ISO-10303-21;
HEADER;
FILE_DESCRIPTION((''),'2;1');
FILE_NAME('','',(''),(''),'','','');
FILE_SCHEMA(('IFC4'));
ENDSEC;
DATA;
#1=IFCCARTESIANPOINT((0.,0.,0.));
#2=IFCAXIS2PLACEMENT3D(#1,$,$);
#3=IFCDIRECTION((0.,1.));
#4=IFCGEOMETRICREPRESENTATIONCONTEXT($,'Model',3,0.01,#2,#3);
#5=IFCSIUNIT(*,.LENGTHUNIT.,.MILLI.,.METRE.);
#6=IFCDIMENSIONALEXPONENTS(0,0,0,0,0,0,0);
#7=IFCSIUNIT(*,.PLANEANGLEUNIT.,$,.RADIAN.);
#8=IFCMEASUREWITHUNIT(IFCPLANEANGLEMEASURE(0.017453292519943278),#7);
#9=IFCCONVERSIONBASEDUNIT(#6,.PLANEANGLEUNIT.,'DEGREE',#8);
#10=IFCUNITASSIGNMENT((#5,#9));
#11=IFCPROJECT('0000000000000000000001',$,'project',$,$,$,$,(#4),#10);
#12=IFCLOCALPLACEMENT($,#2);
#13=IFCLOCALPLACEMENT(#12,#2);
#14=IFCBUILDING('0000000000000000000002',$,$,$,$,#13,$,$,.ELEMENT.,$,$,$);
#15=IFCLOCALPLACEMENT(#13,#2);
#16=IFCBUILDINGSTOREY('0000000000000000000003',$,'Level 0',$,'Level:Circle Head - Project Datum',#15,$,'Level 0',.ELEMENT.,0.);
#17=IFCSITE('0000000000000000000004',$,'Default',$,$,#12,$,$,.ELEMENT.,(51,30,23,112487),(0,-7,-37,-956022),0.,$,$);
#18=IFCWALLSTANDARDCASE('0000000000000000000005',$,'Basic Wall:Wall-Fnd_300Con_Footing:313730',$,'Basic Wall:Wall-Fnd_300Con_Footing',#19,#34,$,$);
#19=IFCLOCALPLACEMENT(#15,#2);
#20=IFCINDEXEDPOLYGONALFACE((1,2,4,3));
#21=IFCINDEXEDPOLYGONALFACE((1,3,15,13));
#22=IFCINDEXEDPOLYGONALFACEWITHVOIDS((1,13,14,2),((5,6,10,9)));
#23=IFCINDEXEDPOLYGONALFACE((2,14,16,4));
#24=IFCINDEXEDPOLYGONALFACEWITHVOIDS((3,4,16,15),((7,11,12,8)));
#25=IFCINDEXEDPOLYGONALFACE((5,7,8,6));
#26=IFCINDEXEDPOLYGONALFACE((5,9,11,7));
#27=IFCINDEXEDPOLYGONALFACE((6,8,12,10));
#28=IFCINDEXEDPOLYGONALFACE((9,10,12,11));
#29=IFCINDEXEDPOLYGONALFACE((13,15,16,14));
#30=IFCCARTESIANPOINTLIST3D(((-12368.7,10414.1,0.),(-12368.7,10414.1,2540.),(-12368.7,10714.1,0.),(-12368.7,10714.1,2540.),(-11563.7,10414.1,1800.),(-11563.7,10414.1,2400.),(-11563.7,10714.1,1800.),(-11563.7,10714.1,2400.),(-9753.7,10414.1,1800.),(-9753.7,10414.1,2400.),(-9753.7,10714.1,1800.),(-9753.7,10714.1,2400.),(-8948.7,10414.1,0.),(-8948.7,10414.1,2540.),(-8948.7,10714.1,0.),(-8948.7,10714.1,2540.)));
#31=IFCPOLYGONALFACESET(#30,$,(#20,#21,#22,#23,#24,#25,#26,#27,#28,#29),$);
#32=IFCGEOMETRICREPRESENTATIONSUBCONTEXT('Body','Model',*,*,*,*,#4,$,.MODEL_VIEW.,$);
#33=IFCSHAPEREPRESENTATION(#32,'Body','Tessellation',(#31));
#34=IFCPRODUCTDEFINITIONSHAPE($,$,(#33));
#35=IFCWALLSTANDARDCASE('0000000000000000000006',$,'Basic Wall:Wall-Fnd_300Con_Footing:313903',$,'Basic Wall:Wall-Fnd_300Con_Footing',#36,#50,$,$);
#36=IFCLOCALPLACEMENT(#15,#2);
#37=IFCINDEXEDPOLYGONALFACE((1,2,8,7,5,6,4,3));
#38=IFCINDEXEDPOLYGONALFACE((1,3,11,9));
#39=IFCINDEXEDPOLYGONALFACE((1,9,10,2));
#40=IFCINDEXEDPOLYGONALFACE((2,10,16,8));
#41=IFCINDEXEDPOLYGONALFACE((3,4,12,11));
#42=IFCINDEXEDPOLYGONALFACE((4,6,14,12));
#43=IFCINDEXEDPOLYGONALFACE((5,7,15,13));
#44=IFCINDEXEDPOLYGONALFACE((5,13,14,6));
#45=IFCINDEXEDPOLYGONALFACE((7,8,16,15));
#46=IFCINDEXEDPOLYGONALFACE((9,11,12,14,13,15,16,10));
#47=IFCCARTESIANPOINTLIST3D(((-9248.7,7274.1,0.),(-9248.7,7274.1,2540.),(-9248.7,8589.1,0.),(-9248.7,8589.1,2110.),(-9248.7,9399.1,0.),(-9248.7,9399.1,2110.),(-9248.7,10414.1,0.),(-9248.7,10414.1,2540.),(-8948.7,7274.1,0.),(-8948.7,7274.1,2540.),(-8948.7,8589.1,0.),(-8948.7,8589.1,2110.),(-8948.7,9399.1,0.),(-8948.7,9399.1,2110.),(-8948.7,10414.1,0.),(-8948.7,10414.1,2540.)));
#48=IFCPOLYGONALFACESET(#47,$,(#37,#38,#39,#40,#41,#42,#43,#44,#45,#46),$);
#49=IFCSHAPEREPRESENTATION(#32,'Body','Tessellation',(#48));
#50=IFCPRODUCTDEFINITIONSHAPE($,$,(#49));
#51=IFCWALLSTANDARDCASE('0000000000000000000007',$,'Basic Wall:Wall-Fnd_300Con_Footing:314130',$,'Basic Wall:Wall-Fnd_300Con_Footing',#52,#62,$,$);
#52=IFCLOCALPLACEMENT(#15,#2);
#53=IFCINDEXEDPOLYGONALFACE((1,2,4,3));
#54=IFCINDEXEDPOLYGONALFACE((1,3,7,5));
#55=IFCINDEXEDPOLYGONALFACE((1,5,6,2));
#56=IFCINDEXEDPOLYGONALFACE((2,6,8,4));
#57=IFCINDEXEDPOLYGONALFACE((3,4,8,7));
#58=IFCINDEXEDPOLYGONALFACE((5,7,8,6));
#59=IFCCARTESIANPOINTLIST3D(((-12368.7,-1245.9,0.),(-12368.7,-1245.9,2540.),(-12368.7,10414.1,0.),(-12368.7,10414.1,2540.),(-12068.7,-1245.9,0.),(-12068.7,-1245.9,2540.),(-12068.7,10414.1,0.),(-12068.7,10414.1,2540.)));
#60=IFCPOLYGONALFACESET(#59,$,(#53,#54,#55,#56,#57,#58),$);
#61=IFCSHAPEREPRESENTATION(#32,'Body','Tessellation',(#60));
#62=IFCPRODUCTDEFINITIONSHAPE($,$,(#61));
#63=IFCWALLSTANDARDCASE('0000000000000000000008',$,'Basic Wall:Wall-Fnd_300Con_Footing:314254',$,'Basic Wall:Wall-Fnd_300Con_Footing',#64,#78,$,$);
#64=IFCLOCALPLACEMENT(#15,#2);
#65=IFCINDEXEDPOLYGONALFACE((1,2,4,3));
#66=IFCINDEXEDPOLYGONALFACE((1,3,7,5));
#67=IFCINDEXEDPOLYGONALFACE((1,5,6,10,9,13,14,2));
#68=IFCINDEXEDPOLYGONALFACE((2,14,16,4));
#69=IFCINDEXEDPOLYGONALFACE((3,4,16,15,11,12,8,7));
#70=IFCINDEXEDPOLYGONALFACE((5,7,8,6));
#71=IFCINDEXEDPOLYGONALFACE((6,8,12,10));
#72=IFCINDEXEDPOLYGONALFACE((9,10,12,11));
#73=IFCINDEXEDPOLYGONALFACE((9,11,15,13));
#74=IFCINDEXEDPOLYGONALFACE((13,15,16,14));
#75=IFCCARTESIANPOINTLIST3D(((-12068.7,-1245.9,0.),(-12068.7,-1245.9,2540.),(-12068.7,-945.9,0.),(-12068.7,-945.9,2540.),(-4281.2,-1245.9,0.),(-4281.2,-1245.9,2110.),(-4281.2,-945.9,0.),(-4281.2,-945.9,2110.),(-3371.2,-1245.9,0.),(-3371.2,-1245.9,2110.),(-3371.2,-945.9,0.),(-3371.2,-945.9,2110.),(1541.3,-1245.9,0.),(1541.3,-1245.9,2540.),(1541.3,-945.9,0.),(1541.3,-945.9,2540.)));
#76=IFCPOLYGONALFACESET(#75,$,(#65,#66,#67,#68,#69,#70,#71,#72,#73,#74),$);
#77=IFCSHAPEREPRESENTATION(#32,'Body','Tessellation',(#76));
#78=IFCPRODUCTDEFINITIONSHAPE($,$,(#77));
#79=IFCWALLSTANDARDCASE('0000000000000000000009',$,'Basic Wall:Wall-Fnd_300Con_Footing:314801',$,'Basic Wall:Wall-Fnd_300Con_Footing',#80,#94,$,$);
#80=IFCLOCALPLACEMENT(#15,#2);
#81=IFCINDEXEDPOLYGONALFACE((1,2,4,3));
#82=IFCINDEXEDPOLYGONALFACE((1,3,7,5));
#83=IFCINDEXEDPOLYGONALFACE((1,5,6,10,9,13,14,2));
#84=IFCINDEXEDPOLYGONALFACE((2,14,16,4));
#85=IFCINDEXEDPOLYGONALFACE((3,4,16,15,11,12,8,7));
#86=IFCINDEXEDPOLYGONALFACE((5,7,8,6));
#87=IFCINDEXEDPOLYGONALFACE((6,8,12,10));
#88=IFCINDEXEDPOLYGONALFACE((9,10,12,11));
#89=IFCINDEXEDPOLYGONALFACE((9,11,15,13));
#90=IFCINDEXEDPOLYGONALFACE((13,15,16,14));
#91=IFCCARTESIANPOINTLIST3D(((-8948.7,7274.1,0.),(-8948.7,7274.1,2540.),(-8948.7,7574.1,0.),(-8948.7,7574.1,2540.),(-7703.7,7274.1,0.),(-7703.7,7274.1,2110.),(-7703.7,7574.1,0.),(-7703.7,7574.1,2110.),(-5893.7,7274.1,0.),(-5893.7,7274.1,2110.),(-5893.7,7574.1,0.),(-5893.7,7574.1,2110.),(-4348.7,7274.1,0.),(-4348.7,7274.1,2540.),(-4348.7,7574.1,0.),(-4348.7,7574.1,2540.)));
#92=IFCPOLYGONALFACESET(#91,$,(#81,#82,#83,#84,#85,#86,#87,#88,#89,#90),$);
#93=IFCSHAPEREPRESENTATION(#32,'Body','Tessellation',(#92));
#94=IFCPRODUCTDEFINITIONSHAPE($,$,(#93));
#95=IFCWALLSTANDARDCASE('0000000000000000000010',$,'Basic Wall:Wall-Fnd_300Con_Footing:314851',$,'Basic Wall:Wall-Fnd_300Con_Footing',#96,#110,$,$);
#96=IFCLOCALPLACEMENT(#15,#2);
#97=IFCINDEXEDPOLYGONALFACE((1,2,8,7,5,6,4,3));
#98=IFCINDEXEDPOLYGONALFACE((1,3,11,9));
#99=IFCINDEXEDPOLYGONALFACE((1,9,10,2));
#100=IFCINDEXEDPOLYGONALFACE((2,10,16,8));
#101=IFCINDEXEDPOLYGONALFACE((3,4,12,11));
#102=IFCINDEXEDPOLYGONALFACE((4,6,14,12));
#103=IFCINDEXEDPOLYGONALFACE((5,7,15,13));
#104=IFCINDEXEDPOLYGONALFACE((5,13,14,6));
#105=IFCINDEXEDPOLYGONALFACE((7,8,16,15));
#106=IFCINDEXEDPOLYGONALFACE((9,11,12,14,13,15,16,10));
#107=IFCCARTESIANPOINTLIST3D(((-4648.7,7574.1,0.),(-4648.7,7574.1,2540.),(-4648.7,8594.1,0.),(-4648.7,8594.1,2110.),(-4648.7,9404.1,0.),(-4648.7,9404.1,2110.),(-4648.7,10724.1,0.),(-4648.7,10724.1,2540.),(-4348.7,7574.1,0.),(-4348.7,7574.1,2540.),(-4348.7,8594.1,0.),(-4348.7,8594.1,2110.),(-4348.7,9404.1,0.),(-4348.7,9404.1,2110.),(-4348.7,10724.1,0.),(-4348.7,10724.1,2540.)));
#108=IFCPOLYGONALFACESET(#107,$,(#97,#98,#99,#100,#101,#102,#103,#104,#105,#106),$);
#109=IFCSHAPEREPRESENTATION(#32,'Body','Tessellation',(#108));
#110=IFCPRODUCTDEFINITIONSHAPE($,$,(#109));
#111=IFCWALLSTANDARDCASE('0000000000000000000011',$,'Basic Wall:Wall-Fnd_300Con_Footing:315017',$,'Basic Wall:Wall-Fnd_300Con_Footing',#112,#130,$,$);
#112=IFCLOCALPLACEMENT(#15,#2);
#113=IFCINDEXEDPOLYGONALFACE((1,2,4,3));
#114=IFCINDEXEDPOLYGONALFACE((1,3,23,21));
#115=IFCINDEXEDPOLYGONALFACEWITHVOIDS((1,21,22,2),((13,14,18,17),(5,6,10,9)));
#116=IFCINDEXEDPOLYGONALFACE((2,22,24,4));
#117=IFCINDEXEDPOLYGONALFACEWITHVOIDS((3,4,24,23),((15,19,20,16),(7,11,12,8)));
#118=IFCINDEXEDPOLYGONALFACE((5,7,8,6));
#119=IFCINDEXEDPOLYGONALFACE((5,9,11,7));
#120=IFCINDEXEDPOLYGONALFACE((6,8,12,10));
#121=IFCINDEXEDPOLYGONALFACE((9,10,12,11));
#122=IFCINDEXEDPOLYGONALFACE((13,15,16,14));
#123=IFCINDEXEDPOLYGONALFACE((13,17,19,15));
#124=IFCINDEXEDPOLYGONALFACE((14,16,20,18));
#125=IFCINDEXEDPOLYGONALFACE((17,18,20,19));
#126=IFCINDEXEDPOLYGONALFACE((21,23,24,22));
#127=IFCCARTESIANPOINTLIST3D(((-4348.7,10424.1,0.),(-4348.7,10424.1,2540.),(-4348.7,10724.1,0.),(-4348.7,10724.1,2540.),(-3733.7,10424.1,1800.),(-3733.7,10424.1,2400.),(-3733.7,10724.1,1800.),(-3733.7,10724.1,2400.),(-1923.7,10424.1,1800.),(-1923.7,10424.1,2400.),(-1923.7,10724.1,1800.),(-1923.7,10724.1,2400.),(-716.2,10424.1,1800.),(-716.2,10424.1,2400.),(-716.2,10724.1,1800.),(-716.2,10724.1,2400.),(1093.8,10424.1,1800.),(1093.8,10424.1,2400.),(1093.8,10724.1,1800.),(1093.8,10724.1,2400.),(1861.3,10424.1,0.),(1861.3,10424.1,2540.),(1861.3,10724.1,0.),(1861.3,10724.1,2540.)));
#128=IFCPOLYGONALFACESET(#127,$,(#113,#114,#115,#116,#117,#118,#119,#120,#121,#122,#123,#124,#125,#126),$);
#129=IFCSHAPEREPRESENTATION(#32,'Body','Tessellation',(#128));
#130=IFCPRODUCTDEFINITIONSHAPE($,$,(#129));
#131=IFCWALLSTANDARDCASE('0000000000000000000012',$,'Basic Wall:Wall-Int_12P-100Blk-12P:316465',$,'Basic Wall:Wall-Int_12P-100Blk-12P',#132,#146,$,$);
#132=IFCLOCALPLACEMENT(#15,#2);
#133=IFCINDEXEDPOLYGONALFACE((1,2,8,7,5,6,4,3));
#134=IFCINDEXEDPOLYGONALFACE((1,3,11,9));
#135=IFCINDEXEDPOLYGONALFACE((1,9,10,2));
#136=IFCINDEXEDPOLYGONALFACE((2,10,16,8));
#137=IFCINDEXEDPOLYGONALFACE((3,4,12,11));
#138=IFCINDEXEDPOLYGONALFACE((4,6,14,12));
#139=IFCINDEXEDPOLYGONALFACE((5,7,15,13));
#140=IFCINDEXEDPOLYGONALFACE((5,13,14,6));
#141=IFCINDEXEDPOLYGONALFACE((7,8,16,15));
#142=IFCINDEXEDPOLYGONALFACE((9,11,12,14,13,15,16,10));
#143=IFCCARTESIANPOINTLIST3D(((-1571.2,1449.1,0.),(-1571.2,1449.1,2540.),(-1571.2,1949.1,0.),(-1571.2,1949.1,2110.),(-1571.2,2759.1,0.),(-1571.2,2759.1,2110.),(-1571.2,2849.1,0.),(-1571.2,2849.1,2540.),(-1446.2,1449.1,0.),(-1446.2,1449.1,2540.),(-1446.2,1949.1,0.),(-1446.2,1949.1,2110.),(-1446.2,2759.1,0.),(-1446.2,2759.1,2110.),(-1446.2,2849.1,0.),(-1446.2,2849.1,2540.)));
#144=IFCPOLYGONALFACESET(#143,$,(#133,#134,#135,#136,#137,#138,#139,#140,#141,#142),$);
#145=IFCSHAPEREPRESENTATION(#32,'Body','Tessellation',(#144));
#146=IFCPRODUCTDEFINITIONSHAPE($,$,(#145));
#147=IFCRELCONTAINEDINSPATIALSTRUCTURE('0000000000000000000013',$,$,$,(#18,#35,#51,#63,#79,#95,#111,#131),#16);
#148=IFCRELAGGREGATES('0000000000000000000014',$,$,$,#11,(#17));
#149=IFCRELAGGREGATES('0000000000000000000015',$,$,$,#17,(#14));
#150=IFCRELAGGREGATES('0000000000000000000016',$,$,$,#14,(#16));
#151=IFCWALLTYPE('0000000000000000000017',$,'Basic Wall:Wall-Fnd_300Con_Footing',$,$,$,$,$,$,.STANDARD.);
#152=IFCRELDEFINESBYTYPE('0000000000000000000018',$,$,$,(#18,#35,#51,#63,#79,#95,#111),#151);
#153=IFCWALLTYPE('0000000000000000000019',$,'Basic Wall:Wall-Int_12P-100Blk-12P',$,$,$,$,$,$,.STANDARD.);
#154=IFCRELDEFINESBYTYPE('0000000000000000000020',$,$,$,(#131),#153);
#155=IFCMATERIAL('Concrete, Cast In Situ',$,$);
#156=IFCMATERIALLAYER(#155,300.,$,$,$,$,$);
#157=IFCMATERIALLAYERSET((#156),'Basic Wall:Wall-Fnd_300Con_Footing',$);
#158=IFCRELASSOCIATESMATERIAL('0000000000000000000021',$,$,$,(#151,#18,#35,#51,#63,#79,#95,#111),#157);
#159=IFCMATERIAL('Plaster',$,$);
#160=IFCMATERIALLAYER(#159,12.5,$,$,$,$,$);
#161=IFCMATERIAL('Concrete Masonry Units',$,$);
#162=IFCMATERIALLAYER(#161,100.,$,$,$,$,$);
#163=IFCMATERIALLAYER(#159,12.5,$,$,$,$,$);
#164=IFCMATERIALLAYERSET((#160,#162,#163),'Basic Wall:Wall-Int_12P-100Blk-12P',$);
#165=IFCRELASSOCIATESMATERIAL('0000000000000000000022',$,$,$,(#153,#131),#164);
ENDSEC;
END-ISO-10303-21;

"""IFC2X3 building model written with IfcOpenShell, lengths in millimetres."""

from ifc_helpers import new_model, entity, si_unit, converted_unit, direction, frame, frame_2d, origin, place, context, subcontext, project, spatial, rectangle, extrude, material, layer, layer_set, layer_usage, type_object, element, save


model = new_model("IFC2X3")

# Units and contexts
model_context = context("Model", 3, precision=0.01, world=origin(), true_north=direction((0.0, 1.0)))
body_context = subcontext(model_context, "Body", "Model", "MODEL_VIEW")
ifc_project = project(units=[si_unit("LENGTHUNIT", "METRE", prefix="MILLI"), converted_unit("PLANEANGLEUNIT", "DEGREE", entity("IfcPlaneAngleMeasure", 0.017453292519943278), si_unit("PLANEANGLEUNIT", "RADIAN"), dimensions=[0, 0, 0, 0, 0, 0, 0])], contexts=[model_context])

# Site, building, storey
site_placement = place(None, origin())
site = spatial("IfcSite", under=ifc_project, at=site_placement, Name="Default", CompositionType="ELEMENT", RefLatitude=(51, 30, 23, 112487), RefLongitude=(0, -7, -37, -956022), RefElevation=0.0)
building_placement = place(site_placement, origin())
building = spatial("IfcBuilding", under=site, at=building_placement, CompositionType="ELEMENT")
storey_placement = place(building_placement, origin())
storey = spatial("IfcBuildingStorey", under=building, at=storey_placement, Name="Level 0", ObjectType="Level:Circle Head - Project Datum", LongName="Level 0", CompositionType="ELEMENT", Elevation=0.0)

# Walls, openings
ifc_material_1 = material(Name="Concrete, Cast In Situ")
ifc_layer_1 = layer(ifc_material_1, 300.0)
ifc_layer_set_1 = layer_set([ifc_layer_1], Name="Basic Wall:Wall-Fnd_300Con_Footing")
ifc_layer_usage_1 = layer_usage(ifc_layer_set_1, "AXIS2", "NEGATIVE", 150.0)
wall_type_1 = type_object("IfcWallType", Name="Basic Wall:Wall-Fnd_300Con_Footing", PredefinedType="STANDARD", material=ifc_layer_set_1)
wall_1_placement = place(storey_placement, frame((-12368.7, 10564.1, 0.0)))
wall_1 = element("IfcWallStandardCase", 1, at=wall_1_placement, inside=storey, type_object=wall_type_1, material=ifc_layer_usage_1, Name="Basic Wall:Wall-Fnd_300Con_Footing:313730", ObjectType="Basic Wall:Wall-Fnd_300Con_Footing", context=body_context, shape_type="SweptSolid", body=[
    extrude(rectangle(XDim=3420.0, YDim=300.0, at=frame_2d((1710.0, 0.0), x_axis=(-1.0, 0.0))), origin(), (0.0, 0.0, 1.0), 2540.0),
])
opening_1_placement = place(wall_1_placement, frame((2615.0, 150.0, 1800.0)))
element("IfcOpeningElement", 2, at=opening_1_placement, cuts=wall_1, ObjectType="Opening", context=body_context, shape_type="SweptSolid", body=[
    extrude(rectangle(XDim=600.0, YDim=1810.0, at=frame_2d((300.0, 905.0), x_axis=(-1.0, 0.0))), frame((0.0, 0.0, 0.0), z_axis=(0.0, -1.0, 0.0), x_axis=(0.0, 0.0, 1.0)), (0.0, 0.0, 1.0), 300.0),
])
wall_2_placement = place(storey_placement, frame((-9098.7, 10414.1, 0.0), z_axis=(0.0, 0.0, 1.0), x_axis=(0.0, -1.0, 0.0)))
wall_2 = element("IfcWallStandardCase", 3, at=wall_2_placement, inside=storey, type_object=wall_type_1, material=ifc_layer_usage_1, Name="Basic Wall:Wall-Fnd_300Con_Footing:313903", ObjectType="Basic Wall:Wall-Fnd_300Con_Footing", context=body_context, shape_type="SweptSolid", body=[
    extrude(rectangle(XDim=3140.0, YDim=300.0, at=frame_2d((1570.0, 0.0), x_axis=(1.0, 0.0))), origin(), (0.0, 0.0, 1.0), 2540.0),
])
opening_2_placement = place(wall_2_placement, frame((1825.0, 150.0, 0.0)))
element("IfcOpeningElement", 4, at=opening_2_placement, cuts=wall_2, ObjectType="Opening", context=body_context, shape_type="SweptSolid", body=[
    extrude(rectangle(XDim=2110.0, YDim=810.0, at=frame_2d((1055.0, 405.0), x_axis=(1.0, 0.0))), frame((0.0, 0.0, 0.0), z_axis=(0.0, -1.0, 0.0), x_axis=(0.0, 0.0, 1.0)), (0.0, 0.0, 1.0), 300.0),
])

# Wall
wall_3_placement = place(storey_placement, frame((-12218.7, 10414.1, 0.0), z_axis=(0.0, 0.0, 1.0), x_axis=(0.0, -1.0, 0.0)))
element("IfcWallStandardCase", 5, at=wall_3_placement, inside=storey, type_object=wall_type_1, material=ifc_layer_usage_1, Name="Basic Wall:Wall-Fnd_300Con_Footing:314130", ObjectType="Basic Wall:Wall-Fnd_300Con_Footing", context=body_context, shape_type="SweptSolid", body=[
    extrude(rectangle(XDim=11660.0, YDim=300.0, at=frame_2d((5830.0, 0.0), x_axis=(-1.0, 0.0))), origin(), (0.0, 0.0, 1.0), 2540.0),
])

# Walls, openings
wall_4_placement = place(storey_placement, frame((-12068.7, -1095.9, 0.0)))
wall_4 = element("IfcWallStandardCase", 6, at=wall_4_placement, inside=storey, type_object=wall_type_1, material=ifc_layer_usage_1, Name="Basic Wall:Wall-Fnd_300Con_Footing:314254", ObjectType="Basic Wall:Wall-Fnd_300Con_Footing", context=body_context, shape_type="SweptSolid", body=[
    extrude(rectangle(XDim=13610.0, YDim=300.0, at=frame_2d((6805.0, 0.0), x_axis=(1.0, 0.0))), origin(), (0.0, 0.0, 1.0), 2540.0),
])
opening_3_placement = place(wall_4_placement, frame((8697.5, 150.0, 0.0)))
element("IfcOpeningElement", 7, at=opening_3_placement, cuts=wall_4, ObjectType="Opening", context=body_context, shape_type="SweptSolid", body=[
    extrude(rectangle(XDim=2110.0, YDim=910.0, at=frame_2d((1055.0, 455.0), x_axis=(1.0, 0.0))), frame((0.0, 0.0, 0.0), z_axis=(0.0, -1.0, 0.0), x_axis=(0.0, 0.0, 1.0)), (0.0, 0.0, 1.0), 300.0),
])
wall_5_placement = place(storey_placement, frame((-8948.7, 7424.1, 0.0)))
wall_5 = element("IfcWallStandardCase", 8, at=wall_5_placement, inside=storey, type_object=wall_type_1, material=ifc_layer_usage_1, Name="Basic Wall:Wall-Fnd_300Con_Footing:314801", ObjectType="Basic Wall:Wall-Fnd_300Con_Footing", context=body_context, shape_type="SweptSolid", body=[
    extrude(rectangle(XDim=4600.0, YDim=300.0, at=frame_2d((2300.0, 0.0), x_axis=(1.0, 0.0))), origin(), (0.0, 0.0, 1.0), 2540.0),
])
opening_4_placement = place(wall_5_placement, frame((3055.0, 150.0, 0.0)))
element("IfcOpeningElement", 9, at=opening_4_placement, cuts=wall_5, ObjectType="Opening", context=body_context, shape_type="SweptSolid", body=[
    extrude(rectangle(XDim=2110.0, YDim=1810.0, at=frame_2d((1055.0, 905.0), x_axis=(-1.0, 0.0))), frame((0.0, 0.0, 0.0), z_axis=(0.0, -1.0, 0.0), x_axis=(0.0, 0.0, 1.0)), (0.0, 0.0, 1.0), 300.0),
])
wall_6_placement = place(storey_placement, frame((-4498.7, 7574.1, 0.0), z_axis=(0.0, 0.0, 1.0), x_axis=(0.0, 1.0, 0.0)))
wall_6 = element("IfcWallStandardCase", 10, at=wall_6_placement, inside=storey, type_object=wall_type_1, material=ifc_layer_usage_1, Name="Basic Wall:Wall-Fnd_300Con_Footing:314851", ObjectType="Basic Wall:Wall-Fnd_300Con_Footing", context=body_context, shape_type="SweptSolid", body=[
    extrude(rectangle(XDim=3150.0, YDim=300.0, at=frame_2d((1575.0, 0.0), x_axis=(1.0, 0.0))), origin(), (0.0, 0.0, 1.0), 2540.0),
])
opening_5_placement = place(wall_6_placement, frame((1830.0, 150.0, 0.0)))
element("IfcOpeningElement", 11, at=opening_5_placement, cuts=wall_6, ObjectType="Opening", context=body_context, shape_type="SweptSolid", body=[
    extrude(rectangle(XDim=2110.0, YDim=810.0, at=frame_2d((1055.0, 405.0), x_axis=(1.0, 0.0))), frame((0.0, 0.0, 0.0), z_axis=(0.0, -1.0, 0.0), x_axis=(0.0, 0.0, 1.0)), (0.0, 0.0, 1.0), 300.0),
])

# Wall, openings
wall_7_placement = place(storey_placement, frame((-4348.7, 10574.1, 0.0)))
wall_7 = element("IfcWallStandardCase", 12, at=wall_7_placement, inside=storey, type_object=wall_type_1, material=ifc_layer_usage_1, Name="Basic Wall:Wall-Fnd_300Con_Footing:315017", ObjectType="Basic Wall:Wall-Fnd_300Con_Footing", context=body_context, shape_type="SweptSolid", body=[
    extrude(rectangle(XDim=6210.0, YDim=300.0, at=frame_2d((3105.0, 0.0), x_axis=(-1.0, 0.0))), origin(), (0.0, 0.0, 1.0), 2540.0),
])
opening_6_placement = place(wall_7_placement, frame((2425.0, 150.0, 1800.0)))
element("IfcOpeningElement", 13, at=opening_6_placement, cuts=wall_7, ObjectType="Opening", context=body_context, shape_type="SweptSolid", body=[
    extrude(rectangle(XDim=600.0, YDim=1810.0, at=frame_2d((300.0, 905.0), x_axis=(-1.0, 0.0))), frame((0.0, 0.0, 0.0), z_axis=(0.0, -1.0, 0.0), x_axis=(0.0, 0.0, 1.0)), (0.0, 0.0, 1.0), 300.0),
])
opening_7_placement = place(wall_7_placement, frame((5442.5, 150.0, 1800.0)))
element("IfcOpeningElement", 14, at=opening_7_placement, cuts=wall_7, ObjectType="Opening", context=body_context, shape_type="SweptSolid", body=[
    extrude(rectangle(XDim=600.0, YDim=1810.0, at=frame_2d((300.0, 905.0), x_axis=(-1.0, 0.0))), frame((0.0, 0.0, 0.0), z_axis=(0.0, -1.0, 0.0), x_axis=(0.0, 0.0, 1.0)), (0.0, 0.0, 1.0), 300.0),
])

# Wall, opening
ifc_material_2 = material(Name="Plaster")
ifc_layer_2 = layer(ifc_material_2, 12.5)
ifc_material_3 = material(Name="Concrete Masonry Units")
ifc_layer_3 = layer(ifc_material_3, 100.0)
ifc_layer_4 = layer(ifc_material_2, 12.5)
ifc_layer_set_2 = layer_set([ifc_layer_2, ifc_layer_3, ifc_layer_4], Name="Basic Wall:Wall-Int_12P-100Blk-12P")
ifc_layer_usage_2 = layer_usage(ifc_layer_set_2, "AXIS2", "NEGATIVE", 62.5)
wall_type_2 = type_object("IfcWallType", Name="Basic Wall:Wall-Int_12P-100Blk-12P", PredefinedType="STANDARD", material=ifc_layer_set_2)
wall_8_placement = place(storey_placement, frame((-1508.7, 2849.1, 0.0), z_axis=(0.0, 0.0, 1.0), x_axis=(0.0, -1.0, 0.0)))
wall_8 = element("IfcWallStandardCase", 15, at=wall_8_placement, inside=storey, type_object=wall_type_2, material=ifc_layer_usage_2, Name="Basic Wall:Wall-Int_12P-100Blk-12P:316465", ObjectType="Basic Wall:Wall-Int_12P-100Blk-12P", context=body_context, shape_type="SweptSolid", body=[
    extrude(rectangle(XDim=1400.0, YDim=125.0, at=frame_2d((700.0, 0.0), x_axis=(1.0, 0.0))), origin(), (0.0, 0.0, 1.0), 2540.0),
])
opening_8_placement = place(wall_8_placement, frame((90.0, -62.5, 0.0)))
element("IfcOpeningElement", 16, at=opening_8_placement, cuts=wall_8, ObjectType="Opening", context=body_context, shape_type="SweptSolid", body=[
    extrude(rectangle(XDim=2110.0, YDim=810.0, at=frame_2d((1055.0, 405.0), x_axis=(1.0, 0.0))), frame((0.0, 0.0, 0.0), z_axis=(0.0, 1.0, 0.0), x_axis=(0.0, 0.0, 1.0)), (0.0, 0.0, 1.0), 125.0),
])

save(model, "model.ifc")
